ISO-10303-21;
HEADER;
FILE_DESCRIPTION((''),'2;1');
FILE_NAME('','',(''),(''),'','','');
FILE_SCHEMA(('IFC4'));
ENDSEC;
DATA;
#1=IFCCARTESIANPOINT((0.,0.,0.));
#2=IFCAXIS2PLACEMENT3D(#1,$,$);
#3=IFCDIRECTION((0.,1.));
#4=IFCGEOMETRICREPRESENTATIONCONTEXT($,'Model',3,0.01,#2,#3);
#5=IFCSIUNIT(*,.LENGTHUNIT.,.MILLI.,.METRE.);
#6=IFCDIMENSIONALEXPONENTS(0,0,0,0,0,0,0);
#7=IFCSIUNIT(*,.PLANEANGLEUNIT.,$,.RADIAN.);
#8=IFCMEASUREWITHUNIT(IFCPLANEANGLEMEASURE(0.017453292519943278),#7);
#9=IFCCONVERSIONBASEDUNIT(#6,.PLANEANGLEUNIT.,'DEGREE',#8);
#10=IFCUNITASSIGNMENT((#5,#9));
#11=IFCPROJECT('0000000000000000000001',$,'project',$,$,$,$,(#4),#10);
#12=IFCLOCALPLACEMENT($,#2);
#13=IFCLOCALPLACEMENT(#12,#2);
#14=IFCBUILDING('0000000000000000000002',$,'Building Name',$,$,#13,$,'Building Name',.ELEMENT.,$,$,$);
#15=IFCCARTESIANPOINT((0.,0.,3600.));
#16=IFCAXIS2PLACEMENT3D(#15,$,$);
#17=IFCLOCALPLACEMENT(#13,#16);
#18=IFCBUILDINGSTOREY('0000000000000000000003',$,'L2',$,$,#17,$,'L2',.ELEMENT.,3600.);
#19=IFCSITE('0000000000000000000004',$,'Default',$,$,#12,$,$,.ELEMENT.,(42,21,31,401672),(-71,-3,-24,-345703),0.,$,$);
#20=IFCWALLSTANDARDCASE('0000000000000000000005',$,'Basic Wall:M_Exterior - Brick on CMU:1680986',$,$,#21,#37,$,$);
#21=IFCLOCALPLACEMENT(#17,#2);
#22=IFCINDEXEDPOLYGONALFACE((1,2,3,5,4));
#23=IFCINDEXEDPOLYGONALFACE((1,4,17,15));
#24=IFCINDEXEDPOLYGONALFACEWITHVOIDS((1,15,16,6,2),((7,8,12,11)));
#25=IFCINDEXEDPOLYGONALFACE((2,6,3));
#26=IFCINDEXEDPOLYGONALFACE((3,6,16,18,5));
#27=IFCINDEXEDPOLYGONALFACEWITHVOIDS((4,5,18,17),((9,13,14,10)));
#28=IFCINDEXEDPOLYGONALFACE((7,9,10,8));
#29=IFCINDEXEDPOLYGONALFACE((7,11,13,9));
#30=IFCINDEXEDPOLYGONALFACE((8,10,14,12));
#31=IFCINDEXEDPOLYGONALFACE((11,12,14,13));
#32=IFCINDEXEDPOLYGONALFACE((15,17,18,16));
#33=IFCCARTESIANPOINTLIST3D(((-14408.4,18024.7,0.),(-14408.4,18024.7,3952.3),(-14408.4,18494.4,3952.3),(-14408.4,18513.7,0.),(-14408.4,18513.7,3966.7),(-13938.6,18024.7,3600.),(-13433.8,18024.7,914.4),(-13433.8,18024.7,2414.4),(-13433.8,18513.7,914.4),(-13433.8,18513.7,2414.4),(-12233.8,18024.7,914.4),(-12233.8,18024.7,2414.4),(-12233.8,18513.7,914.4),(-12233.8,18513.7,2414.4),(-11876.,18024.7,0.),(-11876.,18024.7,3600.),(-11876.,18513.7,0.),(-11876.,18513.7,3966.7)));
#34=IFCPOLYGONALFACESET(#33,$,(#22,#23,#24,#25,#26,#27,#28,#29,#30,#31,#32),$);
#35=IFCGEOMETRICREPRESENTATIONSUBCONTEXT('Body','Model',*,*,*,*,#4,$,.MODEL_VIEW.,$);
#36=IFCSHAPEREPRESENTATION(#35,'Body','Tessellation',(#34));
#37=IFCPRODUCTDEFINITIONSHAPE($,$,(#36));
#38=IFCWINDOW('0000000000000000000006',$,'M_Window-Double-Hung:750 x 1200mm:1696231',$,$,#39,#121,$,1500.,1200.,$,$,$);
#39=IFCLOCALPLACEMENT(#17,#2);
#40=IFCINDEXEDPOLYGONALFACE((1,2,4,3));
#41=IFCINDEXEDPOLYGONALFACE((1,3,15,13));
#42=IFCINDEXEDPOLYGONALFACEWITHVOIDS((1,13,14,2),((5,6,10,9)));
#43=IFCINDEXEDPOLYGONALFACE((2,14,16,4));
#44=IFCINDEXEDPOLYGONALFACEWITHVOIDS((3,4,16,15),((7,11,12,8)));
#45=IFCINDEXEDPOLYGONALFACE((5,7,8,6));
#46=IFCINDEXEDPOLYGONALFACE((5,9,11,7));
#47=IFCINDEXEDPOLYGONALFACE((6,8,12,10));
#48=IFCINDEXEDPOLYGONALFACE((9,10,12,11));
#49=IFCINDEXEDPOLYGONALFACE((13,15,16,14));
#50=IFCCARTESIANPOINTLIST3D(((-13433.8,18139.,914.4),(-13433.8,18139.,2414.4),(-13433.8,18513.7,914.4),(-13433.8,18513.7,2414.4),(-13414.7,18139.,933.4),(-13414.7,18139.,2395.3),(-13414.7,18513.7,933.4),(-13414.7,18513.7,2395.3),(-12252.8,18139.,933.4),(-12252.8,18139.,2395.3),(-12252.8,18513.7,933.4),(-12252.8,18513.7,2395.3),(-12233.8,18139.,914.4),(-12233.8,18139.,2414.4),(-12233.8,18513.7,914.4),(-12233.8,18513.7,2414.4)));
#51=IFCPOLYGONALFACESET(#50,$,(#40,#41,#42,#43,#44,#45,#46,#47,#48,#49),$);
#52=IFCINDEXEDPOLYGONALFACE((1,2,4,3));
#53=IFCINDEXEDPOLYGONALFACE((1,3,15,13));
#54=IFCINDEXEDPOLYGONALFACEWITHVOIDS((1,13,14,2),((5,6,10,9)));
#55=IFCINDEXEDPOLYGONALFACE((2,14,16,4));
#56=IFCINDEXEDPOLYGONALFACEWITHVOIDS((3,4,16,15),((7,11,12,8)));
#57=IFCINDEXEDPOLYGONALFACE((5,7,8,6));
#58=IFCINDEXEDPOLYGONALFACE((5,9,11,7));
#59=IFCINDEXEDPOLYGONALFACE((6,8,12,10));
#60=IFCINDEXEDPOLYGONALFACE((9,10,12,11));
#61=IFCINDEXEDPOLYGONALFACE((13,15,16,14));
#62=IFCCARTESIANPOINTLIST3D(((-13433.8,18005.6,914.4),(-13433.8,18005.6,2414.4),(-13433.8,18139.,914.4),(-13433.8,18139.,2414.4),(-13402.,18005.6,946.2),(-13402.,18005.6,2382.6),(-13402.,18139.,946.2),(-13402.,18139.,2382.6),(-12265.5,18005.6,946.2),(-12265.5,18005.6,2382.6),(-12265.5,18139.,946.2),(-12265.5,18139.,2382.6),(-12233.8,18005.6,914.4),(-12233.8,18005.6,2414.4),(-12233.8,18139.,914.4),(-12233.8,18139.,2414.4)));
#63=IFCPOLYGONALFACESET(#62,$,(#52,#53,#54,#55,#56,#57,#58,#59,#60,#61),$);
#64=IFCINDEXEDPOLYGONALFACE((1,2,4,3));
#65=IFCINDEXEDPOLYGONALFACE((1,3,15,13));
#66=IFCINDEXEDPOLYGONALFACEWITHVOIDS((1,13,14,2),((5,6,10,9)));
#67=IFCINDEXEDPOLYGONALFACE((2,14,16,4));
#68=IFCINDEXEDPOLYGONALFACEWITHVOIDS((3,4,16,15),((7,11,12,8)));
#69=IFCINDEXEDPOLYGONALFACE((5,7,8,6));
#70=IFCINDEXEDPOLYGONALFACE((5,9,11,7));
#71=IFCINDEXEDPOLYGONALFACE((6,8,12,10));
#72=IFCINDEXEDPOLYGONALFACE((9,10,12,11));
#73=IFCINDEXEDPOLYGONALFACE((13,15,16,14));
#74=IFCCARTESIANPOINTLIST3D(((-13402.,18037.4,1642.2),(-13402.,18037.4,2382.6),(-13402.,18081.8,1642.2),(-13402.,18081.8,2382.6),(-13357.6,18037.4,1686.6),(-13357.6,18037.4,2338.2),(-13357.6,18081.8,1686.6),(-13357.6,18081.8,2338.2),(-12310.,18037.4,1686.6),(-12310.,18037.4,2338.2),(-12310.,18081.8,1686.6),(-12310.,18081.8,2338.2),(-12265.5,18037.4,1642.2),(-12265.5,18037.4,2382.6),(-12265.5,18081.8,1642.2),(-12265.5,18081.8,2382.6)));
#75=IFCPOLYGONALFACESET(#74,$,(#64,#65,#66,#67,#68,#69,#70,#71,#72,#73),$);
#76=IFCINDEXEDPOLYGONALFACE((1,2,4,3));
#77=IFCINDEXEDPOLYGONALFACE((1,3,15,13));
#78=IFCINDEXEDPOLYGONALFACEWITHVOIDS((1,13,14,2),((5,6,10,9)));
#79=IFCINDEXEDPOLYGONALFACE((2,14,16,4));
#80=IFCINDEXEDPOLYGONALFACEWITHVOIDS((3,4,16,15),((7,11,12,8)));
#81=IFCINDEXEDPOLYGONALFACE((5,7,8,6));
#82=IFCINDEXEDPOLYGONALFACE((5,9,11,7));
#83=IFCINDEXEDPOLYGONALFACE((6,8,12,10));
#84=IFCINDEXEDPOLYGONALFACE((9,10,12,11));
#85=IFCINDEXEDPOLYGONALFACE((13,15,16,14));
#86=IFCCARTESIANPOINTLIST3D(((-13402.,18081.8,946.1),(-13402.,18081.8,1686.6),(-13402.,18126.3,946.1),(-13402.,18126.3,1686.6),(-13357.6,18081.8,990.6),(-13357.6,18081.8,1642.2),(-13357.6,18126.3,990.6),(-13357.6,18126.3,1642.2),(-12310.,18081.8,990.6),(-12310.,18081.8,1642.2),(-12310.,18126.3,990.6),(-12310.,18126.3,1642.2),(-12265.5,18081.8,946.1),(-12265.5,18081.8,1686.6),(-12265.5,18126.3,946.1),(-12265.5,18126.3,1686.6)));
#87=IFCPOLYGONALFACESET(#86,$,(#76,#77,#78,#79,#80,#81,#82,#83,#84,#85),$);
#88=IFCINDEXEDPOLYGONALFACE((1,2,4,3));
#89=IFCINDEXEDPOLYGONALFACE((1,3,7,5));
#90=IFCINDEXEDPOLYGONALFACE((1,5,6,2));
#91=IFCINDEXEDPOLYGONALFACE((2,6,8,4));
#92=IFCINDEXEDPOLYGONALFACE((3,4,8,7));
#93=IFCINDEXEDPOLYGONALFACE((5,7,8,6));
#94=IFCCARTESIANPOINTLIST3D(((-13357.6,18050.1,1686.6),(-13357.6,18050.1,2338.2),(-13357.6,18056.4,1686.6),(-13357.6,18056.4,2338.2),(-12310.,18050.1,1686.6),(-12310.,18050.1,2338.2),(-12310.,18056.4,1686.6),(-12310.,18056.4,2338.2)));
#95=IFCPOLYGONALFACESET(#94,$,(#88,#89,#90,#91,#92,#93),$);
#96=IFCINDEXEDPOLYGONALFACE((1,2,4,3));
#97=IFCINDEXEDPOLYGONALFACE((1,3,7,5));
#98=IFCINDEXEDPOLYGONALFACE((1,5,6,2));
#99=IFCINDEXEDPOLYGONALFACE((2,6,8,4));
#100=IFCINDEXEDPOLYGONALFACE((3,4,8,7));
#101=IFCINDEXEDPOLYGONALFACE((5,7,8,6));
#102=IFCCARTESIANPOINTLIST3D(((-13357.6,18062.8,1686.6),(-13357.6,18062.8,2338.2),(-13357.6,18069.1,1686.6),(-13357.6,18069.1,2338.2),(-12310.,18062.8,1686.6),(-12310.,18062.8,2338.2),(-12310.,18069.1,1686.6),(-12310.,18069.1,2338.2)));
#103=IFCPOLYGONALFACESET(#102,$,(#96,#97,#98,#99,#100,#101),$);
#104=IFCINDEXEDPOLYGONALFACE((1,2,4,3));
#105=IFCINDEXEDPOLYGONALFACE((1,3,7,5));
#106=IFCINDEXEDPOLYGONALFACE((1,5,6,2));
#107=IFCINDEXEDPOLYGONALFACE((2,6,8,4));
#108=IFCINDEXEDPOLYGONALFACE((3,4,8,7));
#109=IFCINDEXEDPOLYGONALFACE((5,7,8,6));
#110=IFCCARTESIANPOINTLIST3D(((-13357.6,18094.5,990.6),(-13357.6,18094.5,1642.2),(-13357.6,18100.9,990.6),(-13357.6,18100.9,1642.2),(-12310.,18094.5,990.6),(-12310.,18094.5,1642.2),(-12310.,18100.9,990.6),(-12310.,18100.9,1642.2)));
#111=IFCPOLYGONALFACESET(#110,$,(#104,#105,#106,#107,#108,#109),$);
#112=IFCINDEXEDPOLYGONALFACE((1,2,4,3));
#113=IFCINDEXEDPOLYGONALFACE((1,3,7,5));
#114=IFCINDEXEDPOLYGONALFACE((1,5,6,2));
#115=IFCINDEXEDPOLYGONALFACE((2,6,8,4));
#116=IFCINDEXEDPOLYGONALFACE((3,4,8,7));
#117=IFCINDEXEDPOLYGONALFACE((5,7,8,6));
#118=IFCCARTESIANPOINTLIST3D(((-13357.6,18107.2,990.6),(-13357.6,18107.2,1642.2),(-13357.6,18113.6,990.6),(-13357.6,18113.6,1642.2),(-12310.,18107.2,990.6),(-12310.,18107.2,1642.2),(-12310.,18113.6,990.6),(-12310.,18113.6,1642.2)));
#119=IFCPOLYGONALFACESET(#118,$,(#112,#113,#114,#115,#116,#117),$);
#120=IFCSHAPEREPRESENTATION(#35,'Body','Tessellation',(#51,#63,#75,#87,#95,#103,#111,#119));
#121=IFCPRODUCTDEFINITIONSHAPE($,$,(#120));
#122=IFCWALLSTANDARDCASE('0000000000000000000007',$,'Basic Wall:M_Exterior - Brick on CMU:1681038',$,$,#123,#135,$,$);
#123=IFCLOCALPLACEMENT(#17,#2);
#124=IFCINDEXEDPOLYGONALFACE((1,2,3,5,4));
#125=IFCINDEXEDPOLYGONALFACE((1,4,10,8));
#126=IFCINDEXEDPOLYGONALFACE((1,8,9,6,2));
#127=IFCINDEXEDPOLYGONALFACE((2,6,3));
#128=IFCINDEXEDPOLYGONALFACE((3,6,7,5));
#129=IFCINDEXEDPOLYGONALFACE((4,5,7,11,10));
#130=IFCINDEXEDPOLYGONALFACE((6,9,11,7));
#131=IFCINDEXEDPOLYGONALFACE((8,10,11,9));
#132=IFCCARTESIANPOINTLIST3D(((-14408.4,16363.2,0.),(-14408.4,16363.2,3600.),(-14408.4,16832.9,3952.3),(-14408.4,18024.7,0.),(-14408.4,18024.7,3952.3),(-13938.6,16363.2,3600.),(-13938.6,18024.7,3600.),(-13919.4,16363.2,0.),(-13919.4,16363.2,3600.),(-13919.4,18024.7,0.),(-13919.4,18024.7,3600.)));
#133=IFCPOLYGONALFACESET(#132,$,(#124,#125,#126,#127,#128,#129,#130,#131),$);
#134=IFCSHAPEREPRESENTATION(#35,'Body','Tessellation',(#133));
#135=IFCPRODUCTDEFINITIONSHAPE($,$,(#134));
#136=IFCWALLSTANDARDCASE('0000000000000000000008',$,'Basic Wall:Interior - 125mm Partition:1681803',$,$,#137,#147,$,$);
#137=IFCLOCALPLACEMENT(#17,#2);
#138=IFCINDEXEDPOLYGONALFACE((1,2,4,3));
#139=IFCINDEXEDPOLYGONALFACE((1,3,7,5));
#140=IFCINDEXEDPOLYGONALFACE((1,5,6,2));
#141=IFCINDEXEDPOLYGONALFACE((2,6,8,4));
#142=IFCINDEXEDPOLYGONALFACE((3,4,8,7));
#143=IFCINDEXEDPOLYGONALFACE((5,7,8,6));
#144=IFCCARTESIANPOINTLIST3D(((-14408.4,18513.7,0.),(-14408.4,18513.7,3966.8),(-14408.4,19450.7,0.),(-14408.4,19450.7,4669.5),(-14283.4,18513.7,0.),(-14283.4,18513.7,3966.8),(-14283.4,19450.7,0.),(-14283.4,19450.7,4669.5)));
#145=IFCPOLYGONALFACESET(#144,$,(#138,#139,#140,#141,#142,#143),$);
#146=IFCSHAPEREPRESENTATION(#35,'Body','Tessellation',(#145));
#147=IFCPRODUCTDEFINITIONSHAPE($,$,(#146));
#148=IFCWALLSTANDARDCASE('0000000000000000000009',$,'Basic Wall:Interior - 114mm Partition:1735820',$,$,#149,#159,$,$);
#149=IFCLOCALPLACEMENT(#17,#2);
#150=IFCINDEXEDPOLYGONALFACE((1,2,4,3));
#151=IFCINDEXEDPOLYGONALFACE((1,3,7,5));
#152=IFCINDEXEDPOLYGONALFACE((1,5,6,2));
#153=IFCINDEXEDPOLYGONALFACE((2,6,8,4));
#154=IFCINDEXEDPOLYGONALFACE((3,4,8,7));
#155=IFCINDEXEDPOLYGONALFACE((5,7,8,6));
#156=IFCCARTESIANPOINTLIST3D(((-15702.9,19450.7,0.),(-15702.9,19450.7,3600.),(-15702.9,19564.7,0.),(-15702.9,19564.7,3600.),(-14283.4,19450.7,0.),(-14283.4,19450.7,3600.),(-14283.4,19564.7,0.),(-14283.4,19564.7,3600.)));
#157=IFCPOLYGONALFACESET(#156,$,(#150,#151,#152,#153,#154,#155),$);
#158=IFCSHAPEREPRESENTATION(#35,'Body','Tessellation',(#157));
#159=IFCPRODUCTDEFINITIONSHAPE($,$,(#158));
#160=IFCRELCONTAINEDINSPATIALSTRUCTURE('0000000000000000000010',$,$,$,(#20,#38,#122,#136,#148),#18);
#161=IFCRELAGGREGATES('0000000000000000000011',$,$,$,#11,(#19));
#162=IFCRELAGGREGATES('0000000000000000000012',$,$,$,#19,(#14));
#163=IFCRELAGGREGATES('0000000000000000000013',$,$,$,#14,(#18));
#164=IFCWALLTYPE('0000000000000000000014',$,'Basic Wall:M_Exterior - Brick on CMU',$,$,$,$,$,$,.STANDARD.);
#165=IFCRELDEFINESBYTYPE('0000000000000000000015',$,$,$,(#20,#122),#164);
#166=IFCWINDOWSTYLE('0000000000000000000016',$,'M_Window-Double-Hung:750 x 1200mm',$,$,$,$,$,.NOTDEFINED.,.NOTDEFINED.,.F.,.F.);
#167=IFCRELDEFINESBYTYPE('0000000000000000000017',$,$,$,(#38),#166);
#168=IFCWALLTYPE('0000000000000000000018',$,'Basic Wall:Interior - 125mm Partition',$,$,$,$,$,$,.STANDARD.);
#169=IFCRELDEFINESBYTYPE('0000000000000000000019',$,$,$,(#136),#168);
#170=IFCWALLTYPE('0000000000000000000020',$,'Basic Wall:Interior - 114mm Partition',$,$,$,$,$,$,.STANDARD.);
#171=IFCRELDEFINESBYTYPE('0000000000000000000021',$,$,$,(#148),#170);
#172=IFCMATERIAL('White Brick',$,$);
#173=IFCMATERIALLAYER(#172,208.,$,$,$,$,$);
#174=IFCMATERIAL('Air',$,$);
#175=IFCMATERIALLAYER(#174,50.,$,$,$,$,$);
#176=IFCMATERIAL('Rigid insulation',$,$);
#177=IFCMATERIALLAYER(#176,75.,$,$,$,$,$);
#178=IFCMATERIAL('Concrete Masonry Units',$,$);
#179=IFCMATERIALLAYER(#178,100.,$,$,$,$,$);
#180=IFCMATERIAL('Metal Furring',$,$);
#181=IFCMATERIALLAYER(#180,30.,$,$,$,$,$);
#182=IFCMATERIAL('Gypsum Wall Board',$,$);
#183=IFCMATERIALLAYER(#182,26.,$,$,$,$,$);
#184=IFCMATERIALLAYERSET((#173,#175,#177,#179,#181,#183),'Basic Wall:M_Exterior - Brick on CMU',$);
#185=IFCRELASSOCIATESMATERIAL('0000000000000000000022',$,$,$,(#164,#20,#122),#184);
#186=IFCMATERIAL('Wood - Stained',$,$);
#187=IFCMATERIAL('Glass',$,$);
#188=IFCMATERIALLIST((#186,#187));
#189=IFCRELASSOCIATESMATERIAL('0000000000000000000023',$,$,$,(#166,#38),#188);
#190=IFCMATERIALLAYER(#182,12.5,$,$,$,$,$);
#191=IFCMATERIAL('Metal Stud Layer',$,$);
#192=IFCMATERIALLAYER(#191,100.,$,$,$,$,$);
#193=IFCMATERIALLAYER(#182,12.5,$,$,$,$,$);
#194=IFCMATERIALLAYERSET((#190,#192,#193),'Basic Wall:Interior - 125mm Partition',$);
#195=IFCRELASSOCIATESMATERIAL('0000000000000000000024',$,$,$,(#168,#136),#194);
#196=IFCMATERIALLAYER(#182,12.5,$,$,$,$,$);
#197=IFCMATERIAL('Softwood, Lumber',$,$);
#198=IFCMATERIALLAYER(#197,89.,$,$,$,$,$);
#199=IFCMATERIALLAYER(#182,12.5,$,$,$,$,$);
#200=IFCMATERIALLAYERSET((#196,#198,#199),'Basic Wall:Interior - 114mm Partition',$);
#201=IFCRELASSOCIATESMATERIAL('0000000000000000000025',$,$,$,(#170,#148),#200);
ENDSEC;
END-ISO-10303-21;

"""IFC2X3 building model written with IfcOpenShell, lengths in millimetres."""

from ifc_helpers import new_model, entity, si_unit, converted_unit, direction, frame, frame_2d, origin, place, context, subcontext, project, spatial, polyline, rectangle, outline, extrude, clip, bounded_halfspace, source, transform, mapped, material, material_list, layer, layer_set, layer_usage, type_object, type_shapes, element, fill, save


model = new_model("IFC2X3")

# Units and contexts
model_context = context("Model", 3, precision=0.01, world=origin(), true_north=direction((0.0, 1.0)))
body_context = subcontext(model_context, "Body", "Model", "MODEL_VIEW")
ifc_project = project(units=[si_unit("LENGTHUNIT", "METRE", prefix="MILLI"), converted_unit("PLANEANGLEUNIT", "DEGREE", entity("IfcPlaneAngleMeasure", 0.017453292519943278), si_unit("PLANEANGLEUNIT", "RADIAN"), dimensions=[0, 0, 0, 0, 0, 0, 0])], contexts=[model_context])

# Site, building, storey
site_placement = place(None, origin())
site = spatial("IfcSite", under=ifc_project, at=site_placement, Name="Default", CompositionType="ELEMENT", RefLatitude=(42, 21, 31, 401672), RefLongitude=(-71, -3, -24, -345703), RefElevation=0.0)
building_placement = place(site_placement, origin())
building = spatial("IfcBuilding", under=site, at=building_placement, Name="Building Name", LongName="Building Name", CompositionType="ELEMENT")
storey_placement = place(building_placement, frame((0.0, 0.0, 3600.0)))
storey = spatial("IfcBuildingStorey", under=building, at=storey_placement, Name="L2", LongName="L2", CompositionType="ELEMENT", Elevation=3600.0)

# Wall, opening, window
ifc_material_1 = material(Name="White Brick")
ifc_layer_1 = layer(ifc_material_1, 208.0)
ifc_material_2 = material(Name="Air")
ifc_layer_2 = layer(ifc_material_2, 50.0)
ifc_material_3 = material(Name="Rigid insulation")
ifc_layer_3 = layer(ifc_material_3, 75.0)
ifc_material_4 = material(Name="Concrete Masonry Units")
ifc_layer_4 = layer(ifc_material_4, 100.0)
ifc_material_5 = material(Name="Metal Furring")
ifc_layer_5 = layer(ifc_material_5, 30.0)
ifc_material_6 = material(Name="Gypsum Wall Board")
ifc_layer_6 = layer(ifc_material_6, 26.0)
ifc_layer_set_1 = layer_set([ifc_layer_1, ifc_layer_2, ifc_layer_3, ifc_layer_4, ifc_layer_5, ifc_layer_6], Name="Basic Wall:M_Exterior - Brick on CMU")
ifc_layer_usage_1 = layer_usage(ifc_layer_set_1, "AXIS2", "NEGATIVE", 244.5)
wall_type_1 = type_object("IfcWallType", Name="Basic Wall:M_Exterior - Brick on CMU", PredefinedType="STANDARD", material=ifc_layer_set_1)
wall_1_placement = place(storey_placement, frame((-11876.0, 18269.2, 0.0), z_axis=(0.0, 0.0, 1.0), x_axis=(-1.0, 0.0, 0.0)))
wall_1 = element("IfcWallStandardCase", 1, at=wall_1_placement, inside=storey, type_object=wall_type_1, material=ifc_layer_usage_1, Name="Basic Wall:M_Exterior - Brick on CMU:1680986", context=body_context, shape_type="Clipping", body=[
    clip(clip(extrude(rectangle(XDim=2532.3, YDim=489.0, at=frame_2d((1266.2, 0.0), x_axis=(-1.0, 0.0))), origin(), (0.0, 0.0, 1.0), 3966.7), bounded_halfspace(frame((2532.3, -225.2, 3952.3), z_axis=(-0.6, 0.0, 0.8), x_axis=(0.0, -1.0, 0.0)), False, frame((2532.3, -225.2, 3952.3)), polyline([(0.0, 0.0), (0.0, 469.7), (-469.7, 469.7), (0.0, 0.0)]))), bounded_halfspace(frame((0.0, -244.5, 3966.7), z_axis=(0.0, 0.6, 0.8), x_axis=(-1.0, 0.0, 0.0)), False, frame((0.0, -244.5, 3966.7)), polyline([(0.0, 0.0), (2407.3, 0.0), (2532.3, 0.0), (2532.3, 19.3), (2062.6, 489.0), (0.0, 489.0), (0.0, 0.0)]))),
])
opening_1_placement = place(wall_1_placement, frame((357.7, -244.5, 914.4)))
opening_1 = element("IfcOpeningElement", 2, at=opening_1_placement, cuts=wall_1, ObjectType="Opening", context=body_context, shape_type="SweptSolid", body=[
    extrude(rectangle(XDim=1500.0, YDim=1200.0, at=frame_2d((750.0, 600.0), x_axis=(-1.0, 0.0))), frame((0.0, 0.0, 0.0), z_axis=(0.0, 1.0, 0.0), x_axis=(0.0, 0.0, 1.0)), (0.0, 0.0, 1.0), 489.0),
])
ifc_material_7 = material(Name="Wood - Stained")
ifc_material_8 = material(Name="Glass")
ifc_material_list_1 = material_list([ifc_material_7, ifc_material_8])
window_style = type_object("IfcWindowStyle", Name="M_Window-Double-Hung:750 x 1200mm", ConstructionType="NOTDEFINED", OperationType="NOTDEFINED", ParameterTakesPrecedence=False, Sizeable=False, material=ifc_material_list_1)
shared_shape_1 = source(origin(), body_context, "Body", "SweptSolid", [
    extrude(outline(polyline([(-750.0, -600.0), (750.0, -600.0), (750.0, 600.0), (-750.0, 600.0), (-750.0, -600.0)]), holes=[polyline([(-730.9, -580.9), (-730.9, 580.9), (730.9, 580.9), (730.9, -580.9), (-730.9, -580.9)])]), frame((600.0, 0.0, 750.0), z_axis=(0.0, 1.0, 0.0), x_axis=(0.0, 0.0, -1.0)), (0.0, 0.0, 1.0), 374.7),
    extrude(outline(polyline([(-600.0, -750.0), (600.0, -750.0), (600.0, 750.0), (-600.0, 750.0), (-600.0, -750.0)]), holes=[polyline([(568.2, -718.2), (-568.2, -718.2), (-568.2, 718.2), (568.2, 718.2), (568.2, -718.2)])]), frame((600.0, 374.7, 750.0), z_axis=(0.0, 1.0, 0.0), x_axis=(1.0, 0.0, 0.0)), (0.0, 0.0, 1.0), 133.3),
    extrude(outline(polyline([(-568.2, -370.2), (568.2, -370.2), (568.2, 370.2), (-568.2, 370.2), (-568.2, -370.2)]), holes=[polyline([(523.8, -325.8), (-523.8, -325.8), (-523.8, 325.8), (523.8, 325.8), (523.8, -325.8)])]), frame((600.0, 431.8, 1098.0), z_axis=(0.0, 1.0, 0.0), x_axis=(1.0, 0.0, 0.0)), (0.0, 0.0, 1.0), 44.4),
    extrude(outline(polyline([(-568.2, -370.2), (568.2, -370.2), (568.2, 370.2), (-568.2, 370.2), (-568.2, -370.2)]), holes=[polyline([(523.8, -325.8), (-523.8, -325.8), (-523.8, 325.8), (523.8, 325.8), (523.8, -325.8)])]), frame((600.0, 387.4, 402.0), z_axis=(0.0, 1.0, 0.0), x_axis=(1.0, 0.0, 0.0)), (0.0, 0.0, 1.0), 44.5),
    extrude(rectangle(XDim=1047.6, YDim=6.4, at=frame_2d((0.0, 0.0), x_axis=(1.0, 0.0))), frame((600.0, 460.4, 772.2), z_axis=(0.0, 0.0, 1.0), x_axis=(-1.0, 0.0, 0.0)), (0.0, 0.0, 1.0), 651.6),
    extrude(rectangle(XDim=6.4, YDim=1047.6, at=frame_2d((0.0, 0.0), x_axis=(1.0, 0.0))), frame((600.0, 447.7, 772.2), z_axis=(0.0, 0.0, 1.0), x_axis=(0.0, -1.0, 0.0)), (0.0, 0.0, 1.0), 651.6),
    extrude(rectangle(XDim=1047.6, YDim=6.4, at=frame_2d((0.0, 0.0), x_axis=(1.0, 0.0))), frame((600.0, 416.0, 76.2), z_axis=(0.0, 0.0, 1.0), x_axis=(-1.0, 0.0, 0.0)), (0.0, 0.0, 1.0), 651.6),
    extrude(rectangle(XDim=6.4, YDim=1047.6, at=frame_2d((0.0, 0.0), x_axis=(1.0, 0.0))), frame((600.0, 403.3, 76.2), z_axis=(0.0, 0.0, 1.0), x_axis=(0.0, -1.0, 0.0)), (0.0, 0.0, 1.0), 651.6),
])
type_shapes(window_style, [shared_shape_1])
window_1_placement = place(opening_1_placement, origin())
window_1 = element("IfcWindow", 3, at=window_1_placement, inside=storey, type_object=window_style, material=ifc_material_list_1, Name="M_Window-Double-Hung:750 x 1200mm:1696231", OverallHeight=1500.0, OverallWidth=1200.0, context=body_context, shape_type="MappedRepresentation", body=[
    mapped(shared_shape_1, transform((0.0, 0.0, 0.0), scale=1.0)),
])
fill(opening_1, window_1)

# Wall
ifc_layer_usage_2 = layer_usage(ifc_layer_set_1, "AXIS2", "NEGATIVE", 244.5)
wall_2_placement = place(storey_placement, frame((-14163.9, 18024.7, 0.0), z_axis=(0.0, 0.0, 1.0), x_axis=(0.0, -1.0, 0.0)))
element("IfcWallStandardCase", 4, at=wall_2_placement, inside=storey, type_object=wall_type_1, material=ifc_layer_usage_2, Name="Basic Wall:M_Exterior - Brick on CMU:1681038", context=body_context, shape_type="Clipping", body=[
    clip(clip(clip(extrude(rectangle(XDim=1661.5, YDim=489.0, at=frame_2d((830.8, 0.0), x_axis=(-1.0, 0.0))), origin(), (0.0, 0.0, 1.0), 3952.3), bounded_halfspace(frame((1191.8, -244.5, 3952.3), z_axis=(0.6, 0.0, 0.8), x_axis=(0.0, 1.0, 0.0)), False, frame((1191.8, -244.5, 3952.3)), polyline([(0.0, 0.0), (469.7, 0.0), (469.7, 469.7), (0.0, 0.0)]))), bounded_halfspace(frame((0.0, -244.5, 3952.3), z_axis=(0.0, 0.6, 0.8), x_axis=(-1.0, 0.0, 0.0)), False, frame((0.0, -244.5, 3952.3)), polyline([(0.0, 0.0), (1172.5, 0.0), (1191.8, 0.0), (1661.5, 469.7), (0.0, 469.7), (0.0, 0.0)]))), bounded_halfspace(frame((1661.5, 225.2, 3600.0), z_axis=(0.0, 0.0, 1.0), x_axis=(0.0, 1.0, 0.0)), False, frame((1661.5, 225.2, 3600.0)), polyline([(0.0, 0.0), (0.0, 19.3), (-1661.5, 19.3), (-1661.5, 0.0), (0.0, 0.0)]))),
])

# Walls
ifc_layer_7 = layer(ifc_material_6, 12.5)
ifc_material_9 = material(Name="Metal Stud Layer")
ifc_layer_8 = layer(ifc_material_9, 100.0)
ifc_layer_9 = layer(ifc_material_6, 12.5)
ifc_layer_set_2 = layer_set([ifc_layer_7, ifc_layer_8, ifc_layer_9], Name="Basic Wall:Interior - 125mm Partition")
ifc_layer_usage_3 = layer_usage(ifc_layer_set_2, "AXIS2", "NEGATIVE", 62.5)
wall_type_2 = type_object("IfcWallType", Name="Basic Wall:Interior - 125mm Partition", PredefinedType="STANDARD", material=ifc_layer_set_2)
wall_3_placement = place(storey_placement, frame((-14345.9, 18513.7, 0.0), z_axis=(0.0, 0.0, 1.0), x_axis=(0.0, 1.0, 0.0)))
element("IfcWallStandardCase", 5, at=wall_3_placement, inside=storey, type_object=wall_type_2, material=ifc_layer_usage_3, Name="Basic Wall:Interior - 125mm Partition:1681803", context=body_context, shape_type="Clipping", body=[
    clip(extrude(rectangle(XDim=937.0, YDim=125.0, at=frame_2d((468.5, 0.0), x_axis=(-1.0, 0.0))), origin(), (0.0, 0.0, 1.0), 4669.5), bounded_halfspace(frame((0.0, -62.5, 3966.7), z_axis=(-0.6, 0.0, 0.8), x_axis=(0.0, -1.0, 0.0)), False, frame((0.0, -62.5, 3966.7)), polyline([(0.0, 0.0), (937.0, 0.0), (937.0, 125.0), (0.0, 125.0), (0.0, 0.0)]))),
])
ifc_layer_10 = layer(ifc_material_6, 12.5)
ifc_material_10 = material(Name="Softwood, Lumber")
ifc_layer_11 = layer(ifc_material_10, 89.0)
ifc_layer_12 = layer(ifc_material_6, 12.5)
ifc_layer_set_3 = layer_set([ifc_layer_10, ifc_layer_11, ifc_layer_12], Name="Basic Wall:Interior - 114mm Partition")
ifc_layer_usage_4 = layer_usage(ifc_layer_set_3, "AXIS2", "NEGATIVE", 57.0)
wall_type_3 = type_object("IfcWallType", Name="Basic Wall:Interior - 114mm Partition", PredefinedType="STANDARD", material=ifc_layer_set_3)
wall_4_placement = place(storey_placement, frame((-14283.4, 19507.7, 0.0), z_axis=(0.0, 0.0, 1.0), x_axis=(-1.0, 0.0, 0.0)))
element("IfcWallStandardCase", 6, at=wall_4_placement, inside=storey, type_object=wall_type_3, material=ifc_layer_usage_4, Name="Basic Wall:Interior - 114mm Partition:1735820", context=body_context, shape_type="SweptSolid", body=[
    extrude(rectangle(XDim=1419.5, YDim=114.0, at=frame_2d((709.8, 0.0), x_axis=(-1.0, 0.0))), origin(), (0.0, 0.0, 1.0), 3600.0),
])

save(model, "model.ifc")
